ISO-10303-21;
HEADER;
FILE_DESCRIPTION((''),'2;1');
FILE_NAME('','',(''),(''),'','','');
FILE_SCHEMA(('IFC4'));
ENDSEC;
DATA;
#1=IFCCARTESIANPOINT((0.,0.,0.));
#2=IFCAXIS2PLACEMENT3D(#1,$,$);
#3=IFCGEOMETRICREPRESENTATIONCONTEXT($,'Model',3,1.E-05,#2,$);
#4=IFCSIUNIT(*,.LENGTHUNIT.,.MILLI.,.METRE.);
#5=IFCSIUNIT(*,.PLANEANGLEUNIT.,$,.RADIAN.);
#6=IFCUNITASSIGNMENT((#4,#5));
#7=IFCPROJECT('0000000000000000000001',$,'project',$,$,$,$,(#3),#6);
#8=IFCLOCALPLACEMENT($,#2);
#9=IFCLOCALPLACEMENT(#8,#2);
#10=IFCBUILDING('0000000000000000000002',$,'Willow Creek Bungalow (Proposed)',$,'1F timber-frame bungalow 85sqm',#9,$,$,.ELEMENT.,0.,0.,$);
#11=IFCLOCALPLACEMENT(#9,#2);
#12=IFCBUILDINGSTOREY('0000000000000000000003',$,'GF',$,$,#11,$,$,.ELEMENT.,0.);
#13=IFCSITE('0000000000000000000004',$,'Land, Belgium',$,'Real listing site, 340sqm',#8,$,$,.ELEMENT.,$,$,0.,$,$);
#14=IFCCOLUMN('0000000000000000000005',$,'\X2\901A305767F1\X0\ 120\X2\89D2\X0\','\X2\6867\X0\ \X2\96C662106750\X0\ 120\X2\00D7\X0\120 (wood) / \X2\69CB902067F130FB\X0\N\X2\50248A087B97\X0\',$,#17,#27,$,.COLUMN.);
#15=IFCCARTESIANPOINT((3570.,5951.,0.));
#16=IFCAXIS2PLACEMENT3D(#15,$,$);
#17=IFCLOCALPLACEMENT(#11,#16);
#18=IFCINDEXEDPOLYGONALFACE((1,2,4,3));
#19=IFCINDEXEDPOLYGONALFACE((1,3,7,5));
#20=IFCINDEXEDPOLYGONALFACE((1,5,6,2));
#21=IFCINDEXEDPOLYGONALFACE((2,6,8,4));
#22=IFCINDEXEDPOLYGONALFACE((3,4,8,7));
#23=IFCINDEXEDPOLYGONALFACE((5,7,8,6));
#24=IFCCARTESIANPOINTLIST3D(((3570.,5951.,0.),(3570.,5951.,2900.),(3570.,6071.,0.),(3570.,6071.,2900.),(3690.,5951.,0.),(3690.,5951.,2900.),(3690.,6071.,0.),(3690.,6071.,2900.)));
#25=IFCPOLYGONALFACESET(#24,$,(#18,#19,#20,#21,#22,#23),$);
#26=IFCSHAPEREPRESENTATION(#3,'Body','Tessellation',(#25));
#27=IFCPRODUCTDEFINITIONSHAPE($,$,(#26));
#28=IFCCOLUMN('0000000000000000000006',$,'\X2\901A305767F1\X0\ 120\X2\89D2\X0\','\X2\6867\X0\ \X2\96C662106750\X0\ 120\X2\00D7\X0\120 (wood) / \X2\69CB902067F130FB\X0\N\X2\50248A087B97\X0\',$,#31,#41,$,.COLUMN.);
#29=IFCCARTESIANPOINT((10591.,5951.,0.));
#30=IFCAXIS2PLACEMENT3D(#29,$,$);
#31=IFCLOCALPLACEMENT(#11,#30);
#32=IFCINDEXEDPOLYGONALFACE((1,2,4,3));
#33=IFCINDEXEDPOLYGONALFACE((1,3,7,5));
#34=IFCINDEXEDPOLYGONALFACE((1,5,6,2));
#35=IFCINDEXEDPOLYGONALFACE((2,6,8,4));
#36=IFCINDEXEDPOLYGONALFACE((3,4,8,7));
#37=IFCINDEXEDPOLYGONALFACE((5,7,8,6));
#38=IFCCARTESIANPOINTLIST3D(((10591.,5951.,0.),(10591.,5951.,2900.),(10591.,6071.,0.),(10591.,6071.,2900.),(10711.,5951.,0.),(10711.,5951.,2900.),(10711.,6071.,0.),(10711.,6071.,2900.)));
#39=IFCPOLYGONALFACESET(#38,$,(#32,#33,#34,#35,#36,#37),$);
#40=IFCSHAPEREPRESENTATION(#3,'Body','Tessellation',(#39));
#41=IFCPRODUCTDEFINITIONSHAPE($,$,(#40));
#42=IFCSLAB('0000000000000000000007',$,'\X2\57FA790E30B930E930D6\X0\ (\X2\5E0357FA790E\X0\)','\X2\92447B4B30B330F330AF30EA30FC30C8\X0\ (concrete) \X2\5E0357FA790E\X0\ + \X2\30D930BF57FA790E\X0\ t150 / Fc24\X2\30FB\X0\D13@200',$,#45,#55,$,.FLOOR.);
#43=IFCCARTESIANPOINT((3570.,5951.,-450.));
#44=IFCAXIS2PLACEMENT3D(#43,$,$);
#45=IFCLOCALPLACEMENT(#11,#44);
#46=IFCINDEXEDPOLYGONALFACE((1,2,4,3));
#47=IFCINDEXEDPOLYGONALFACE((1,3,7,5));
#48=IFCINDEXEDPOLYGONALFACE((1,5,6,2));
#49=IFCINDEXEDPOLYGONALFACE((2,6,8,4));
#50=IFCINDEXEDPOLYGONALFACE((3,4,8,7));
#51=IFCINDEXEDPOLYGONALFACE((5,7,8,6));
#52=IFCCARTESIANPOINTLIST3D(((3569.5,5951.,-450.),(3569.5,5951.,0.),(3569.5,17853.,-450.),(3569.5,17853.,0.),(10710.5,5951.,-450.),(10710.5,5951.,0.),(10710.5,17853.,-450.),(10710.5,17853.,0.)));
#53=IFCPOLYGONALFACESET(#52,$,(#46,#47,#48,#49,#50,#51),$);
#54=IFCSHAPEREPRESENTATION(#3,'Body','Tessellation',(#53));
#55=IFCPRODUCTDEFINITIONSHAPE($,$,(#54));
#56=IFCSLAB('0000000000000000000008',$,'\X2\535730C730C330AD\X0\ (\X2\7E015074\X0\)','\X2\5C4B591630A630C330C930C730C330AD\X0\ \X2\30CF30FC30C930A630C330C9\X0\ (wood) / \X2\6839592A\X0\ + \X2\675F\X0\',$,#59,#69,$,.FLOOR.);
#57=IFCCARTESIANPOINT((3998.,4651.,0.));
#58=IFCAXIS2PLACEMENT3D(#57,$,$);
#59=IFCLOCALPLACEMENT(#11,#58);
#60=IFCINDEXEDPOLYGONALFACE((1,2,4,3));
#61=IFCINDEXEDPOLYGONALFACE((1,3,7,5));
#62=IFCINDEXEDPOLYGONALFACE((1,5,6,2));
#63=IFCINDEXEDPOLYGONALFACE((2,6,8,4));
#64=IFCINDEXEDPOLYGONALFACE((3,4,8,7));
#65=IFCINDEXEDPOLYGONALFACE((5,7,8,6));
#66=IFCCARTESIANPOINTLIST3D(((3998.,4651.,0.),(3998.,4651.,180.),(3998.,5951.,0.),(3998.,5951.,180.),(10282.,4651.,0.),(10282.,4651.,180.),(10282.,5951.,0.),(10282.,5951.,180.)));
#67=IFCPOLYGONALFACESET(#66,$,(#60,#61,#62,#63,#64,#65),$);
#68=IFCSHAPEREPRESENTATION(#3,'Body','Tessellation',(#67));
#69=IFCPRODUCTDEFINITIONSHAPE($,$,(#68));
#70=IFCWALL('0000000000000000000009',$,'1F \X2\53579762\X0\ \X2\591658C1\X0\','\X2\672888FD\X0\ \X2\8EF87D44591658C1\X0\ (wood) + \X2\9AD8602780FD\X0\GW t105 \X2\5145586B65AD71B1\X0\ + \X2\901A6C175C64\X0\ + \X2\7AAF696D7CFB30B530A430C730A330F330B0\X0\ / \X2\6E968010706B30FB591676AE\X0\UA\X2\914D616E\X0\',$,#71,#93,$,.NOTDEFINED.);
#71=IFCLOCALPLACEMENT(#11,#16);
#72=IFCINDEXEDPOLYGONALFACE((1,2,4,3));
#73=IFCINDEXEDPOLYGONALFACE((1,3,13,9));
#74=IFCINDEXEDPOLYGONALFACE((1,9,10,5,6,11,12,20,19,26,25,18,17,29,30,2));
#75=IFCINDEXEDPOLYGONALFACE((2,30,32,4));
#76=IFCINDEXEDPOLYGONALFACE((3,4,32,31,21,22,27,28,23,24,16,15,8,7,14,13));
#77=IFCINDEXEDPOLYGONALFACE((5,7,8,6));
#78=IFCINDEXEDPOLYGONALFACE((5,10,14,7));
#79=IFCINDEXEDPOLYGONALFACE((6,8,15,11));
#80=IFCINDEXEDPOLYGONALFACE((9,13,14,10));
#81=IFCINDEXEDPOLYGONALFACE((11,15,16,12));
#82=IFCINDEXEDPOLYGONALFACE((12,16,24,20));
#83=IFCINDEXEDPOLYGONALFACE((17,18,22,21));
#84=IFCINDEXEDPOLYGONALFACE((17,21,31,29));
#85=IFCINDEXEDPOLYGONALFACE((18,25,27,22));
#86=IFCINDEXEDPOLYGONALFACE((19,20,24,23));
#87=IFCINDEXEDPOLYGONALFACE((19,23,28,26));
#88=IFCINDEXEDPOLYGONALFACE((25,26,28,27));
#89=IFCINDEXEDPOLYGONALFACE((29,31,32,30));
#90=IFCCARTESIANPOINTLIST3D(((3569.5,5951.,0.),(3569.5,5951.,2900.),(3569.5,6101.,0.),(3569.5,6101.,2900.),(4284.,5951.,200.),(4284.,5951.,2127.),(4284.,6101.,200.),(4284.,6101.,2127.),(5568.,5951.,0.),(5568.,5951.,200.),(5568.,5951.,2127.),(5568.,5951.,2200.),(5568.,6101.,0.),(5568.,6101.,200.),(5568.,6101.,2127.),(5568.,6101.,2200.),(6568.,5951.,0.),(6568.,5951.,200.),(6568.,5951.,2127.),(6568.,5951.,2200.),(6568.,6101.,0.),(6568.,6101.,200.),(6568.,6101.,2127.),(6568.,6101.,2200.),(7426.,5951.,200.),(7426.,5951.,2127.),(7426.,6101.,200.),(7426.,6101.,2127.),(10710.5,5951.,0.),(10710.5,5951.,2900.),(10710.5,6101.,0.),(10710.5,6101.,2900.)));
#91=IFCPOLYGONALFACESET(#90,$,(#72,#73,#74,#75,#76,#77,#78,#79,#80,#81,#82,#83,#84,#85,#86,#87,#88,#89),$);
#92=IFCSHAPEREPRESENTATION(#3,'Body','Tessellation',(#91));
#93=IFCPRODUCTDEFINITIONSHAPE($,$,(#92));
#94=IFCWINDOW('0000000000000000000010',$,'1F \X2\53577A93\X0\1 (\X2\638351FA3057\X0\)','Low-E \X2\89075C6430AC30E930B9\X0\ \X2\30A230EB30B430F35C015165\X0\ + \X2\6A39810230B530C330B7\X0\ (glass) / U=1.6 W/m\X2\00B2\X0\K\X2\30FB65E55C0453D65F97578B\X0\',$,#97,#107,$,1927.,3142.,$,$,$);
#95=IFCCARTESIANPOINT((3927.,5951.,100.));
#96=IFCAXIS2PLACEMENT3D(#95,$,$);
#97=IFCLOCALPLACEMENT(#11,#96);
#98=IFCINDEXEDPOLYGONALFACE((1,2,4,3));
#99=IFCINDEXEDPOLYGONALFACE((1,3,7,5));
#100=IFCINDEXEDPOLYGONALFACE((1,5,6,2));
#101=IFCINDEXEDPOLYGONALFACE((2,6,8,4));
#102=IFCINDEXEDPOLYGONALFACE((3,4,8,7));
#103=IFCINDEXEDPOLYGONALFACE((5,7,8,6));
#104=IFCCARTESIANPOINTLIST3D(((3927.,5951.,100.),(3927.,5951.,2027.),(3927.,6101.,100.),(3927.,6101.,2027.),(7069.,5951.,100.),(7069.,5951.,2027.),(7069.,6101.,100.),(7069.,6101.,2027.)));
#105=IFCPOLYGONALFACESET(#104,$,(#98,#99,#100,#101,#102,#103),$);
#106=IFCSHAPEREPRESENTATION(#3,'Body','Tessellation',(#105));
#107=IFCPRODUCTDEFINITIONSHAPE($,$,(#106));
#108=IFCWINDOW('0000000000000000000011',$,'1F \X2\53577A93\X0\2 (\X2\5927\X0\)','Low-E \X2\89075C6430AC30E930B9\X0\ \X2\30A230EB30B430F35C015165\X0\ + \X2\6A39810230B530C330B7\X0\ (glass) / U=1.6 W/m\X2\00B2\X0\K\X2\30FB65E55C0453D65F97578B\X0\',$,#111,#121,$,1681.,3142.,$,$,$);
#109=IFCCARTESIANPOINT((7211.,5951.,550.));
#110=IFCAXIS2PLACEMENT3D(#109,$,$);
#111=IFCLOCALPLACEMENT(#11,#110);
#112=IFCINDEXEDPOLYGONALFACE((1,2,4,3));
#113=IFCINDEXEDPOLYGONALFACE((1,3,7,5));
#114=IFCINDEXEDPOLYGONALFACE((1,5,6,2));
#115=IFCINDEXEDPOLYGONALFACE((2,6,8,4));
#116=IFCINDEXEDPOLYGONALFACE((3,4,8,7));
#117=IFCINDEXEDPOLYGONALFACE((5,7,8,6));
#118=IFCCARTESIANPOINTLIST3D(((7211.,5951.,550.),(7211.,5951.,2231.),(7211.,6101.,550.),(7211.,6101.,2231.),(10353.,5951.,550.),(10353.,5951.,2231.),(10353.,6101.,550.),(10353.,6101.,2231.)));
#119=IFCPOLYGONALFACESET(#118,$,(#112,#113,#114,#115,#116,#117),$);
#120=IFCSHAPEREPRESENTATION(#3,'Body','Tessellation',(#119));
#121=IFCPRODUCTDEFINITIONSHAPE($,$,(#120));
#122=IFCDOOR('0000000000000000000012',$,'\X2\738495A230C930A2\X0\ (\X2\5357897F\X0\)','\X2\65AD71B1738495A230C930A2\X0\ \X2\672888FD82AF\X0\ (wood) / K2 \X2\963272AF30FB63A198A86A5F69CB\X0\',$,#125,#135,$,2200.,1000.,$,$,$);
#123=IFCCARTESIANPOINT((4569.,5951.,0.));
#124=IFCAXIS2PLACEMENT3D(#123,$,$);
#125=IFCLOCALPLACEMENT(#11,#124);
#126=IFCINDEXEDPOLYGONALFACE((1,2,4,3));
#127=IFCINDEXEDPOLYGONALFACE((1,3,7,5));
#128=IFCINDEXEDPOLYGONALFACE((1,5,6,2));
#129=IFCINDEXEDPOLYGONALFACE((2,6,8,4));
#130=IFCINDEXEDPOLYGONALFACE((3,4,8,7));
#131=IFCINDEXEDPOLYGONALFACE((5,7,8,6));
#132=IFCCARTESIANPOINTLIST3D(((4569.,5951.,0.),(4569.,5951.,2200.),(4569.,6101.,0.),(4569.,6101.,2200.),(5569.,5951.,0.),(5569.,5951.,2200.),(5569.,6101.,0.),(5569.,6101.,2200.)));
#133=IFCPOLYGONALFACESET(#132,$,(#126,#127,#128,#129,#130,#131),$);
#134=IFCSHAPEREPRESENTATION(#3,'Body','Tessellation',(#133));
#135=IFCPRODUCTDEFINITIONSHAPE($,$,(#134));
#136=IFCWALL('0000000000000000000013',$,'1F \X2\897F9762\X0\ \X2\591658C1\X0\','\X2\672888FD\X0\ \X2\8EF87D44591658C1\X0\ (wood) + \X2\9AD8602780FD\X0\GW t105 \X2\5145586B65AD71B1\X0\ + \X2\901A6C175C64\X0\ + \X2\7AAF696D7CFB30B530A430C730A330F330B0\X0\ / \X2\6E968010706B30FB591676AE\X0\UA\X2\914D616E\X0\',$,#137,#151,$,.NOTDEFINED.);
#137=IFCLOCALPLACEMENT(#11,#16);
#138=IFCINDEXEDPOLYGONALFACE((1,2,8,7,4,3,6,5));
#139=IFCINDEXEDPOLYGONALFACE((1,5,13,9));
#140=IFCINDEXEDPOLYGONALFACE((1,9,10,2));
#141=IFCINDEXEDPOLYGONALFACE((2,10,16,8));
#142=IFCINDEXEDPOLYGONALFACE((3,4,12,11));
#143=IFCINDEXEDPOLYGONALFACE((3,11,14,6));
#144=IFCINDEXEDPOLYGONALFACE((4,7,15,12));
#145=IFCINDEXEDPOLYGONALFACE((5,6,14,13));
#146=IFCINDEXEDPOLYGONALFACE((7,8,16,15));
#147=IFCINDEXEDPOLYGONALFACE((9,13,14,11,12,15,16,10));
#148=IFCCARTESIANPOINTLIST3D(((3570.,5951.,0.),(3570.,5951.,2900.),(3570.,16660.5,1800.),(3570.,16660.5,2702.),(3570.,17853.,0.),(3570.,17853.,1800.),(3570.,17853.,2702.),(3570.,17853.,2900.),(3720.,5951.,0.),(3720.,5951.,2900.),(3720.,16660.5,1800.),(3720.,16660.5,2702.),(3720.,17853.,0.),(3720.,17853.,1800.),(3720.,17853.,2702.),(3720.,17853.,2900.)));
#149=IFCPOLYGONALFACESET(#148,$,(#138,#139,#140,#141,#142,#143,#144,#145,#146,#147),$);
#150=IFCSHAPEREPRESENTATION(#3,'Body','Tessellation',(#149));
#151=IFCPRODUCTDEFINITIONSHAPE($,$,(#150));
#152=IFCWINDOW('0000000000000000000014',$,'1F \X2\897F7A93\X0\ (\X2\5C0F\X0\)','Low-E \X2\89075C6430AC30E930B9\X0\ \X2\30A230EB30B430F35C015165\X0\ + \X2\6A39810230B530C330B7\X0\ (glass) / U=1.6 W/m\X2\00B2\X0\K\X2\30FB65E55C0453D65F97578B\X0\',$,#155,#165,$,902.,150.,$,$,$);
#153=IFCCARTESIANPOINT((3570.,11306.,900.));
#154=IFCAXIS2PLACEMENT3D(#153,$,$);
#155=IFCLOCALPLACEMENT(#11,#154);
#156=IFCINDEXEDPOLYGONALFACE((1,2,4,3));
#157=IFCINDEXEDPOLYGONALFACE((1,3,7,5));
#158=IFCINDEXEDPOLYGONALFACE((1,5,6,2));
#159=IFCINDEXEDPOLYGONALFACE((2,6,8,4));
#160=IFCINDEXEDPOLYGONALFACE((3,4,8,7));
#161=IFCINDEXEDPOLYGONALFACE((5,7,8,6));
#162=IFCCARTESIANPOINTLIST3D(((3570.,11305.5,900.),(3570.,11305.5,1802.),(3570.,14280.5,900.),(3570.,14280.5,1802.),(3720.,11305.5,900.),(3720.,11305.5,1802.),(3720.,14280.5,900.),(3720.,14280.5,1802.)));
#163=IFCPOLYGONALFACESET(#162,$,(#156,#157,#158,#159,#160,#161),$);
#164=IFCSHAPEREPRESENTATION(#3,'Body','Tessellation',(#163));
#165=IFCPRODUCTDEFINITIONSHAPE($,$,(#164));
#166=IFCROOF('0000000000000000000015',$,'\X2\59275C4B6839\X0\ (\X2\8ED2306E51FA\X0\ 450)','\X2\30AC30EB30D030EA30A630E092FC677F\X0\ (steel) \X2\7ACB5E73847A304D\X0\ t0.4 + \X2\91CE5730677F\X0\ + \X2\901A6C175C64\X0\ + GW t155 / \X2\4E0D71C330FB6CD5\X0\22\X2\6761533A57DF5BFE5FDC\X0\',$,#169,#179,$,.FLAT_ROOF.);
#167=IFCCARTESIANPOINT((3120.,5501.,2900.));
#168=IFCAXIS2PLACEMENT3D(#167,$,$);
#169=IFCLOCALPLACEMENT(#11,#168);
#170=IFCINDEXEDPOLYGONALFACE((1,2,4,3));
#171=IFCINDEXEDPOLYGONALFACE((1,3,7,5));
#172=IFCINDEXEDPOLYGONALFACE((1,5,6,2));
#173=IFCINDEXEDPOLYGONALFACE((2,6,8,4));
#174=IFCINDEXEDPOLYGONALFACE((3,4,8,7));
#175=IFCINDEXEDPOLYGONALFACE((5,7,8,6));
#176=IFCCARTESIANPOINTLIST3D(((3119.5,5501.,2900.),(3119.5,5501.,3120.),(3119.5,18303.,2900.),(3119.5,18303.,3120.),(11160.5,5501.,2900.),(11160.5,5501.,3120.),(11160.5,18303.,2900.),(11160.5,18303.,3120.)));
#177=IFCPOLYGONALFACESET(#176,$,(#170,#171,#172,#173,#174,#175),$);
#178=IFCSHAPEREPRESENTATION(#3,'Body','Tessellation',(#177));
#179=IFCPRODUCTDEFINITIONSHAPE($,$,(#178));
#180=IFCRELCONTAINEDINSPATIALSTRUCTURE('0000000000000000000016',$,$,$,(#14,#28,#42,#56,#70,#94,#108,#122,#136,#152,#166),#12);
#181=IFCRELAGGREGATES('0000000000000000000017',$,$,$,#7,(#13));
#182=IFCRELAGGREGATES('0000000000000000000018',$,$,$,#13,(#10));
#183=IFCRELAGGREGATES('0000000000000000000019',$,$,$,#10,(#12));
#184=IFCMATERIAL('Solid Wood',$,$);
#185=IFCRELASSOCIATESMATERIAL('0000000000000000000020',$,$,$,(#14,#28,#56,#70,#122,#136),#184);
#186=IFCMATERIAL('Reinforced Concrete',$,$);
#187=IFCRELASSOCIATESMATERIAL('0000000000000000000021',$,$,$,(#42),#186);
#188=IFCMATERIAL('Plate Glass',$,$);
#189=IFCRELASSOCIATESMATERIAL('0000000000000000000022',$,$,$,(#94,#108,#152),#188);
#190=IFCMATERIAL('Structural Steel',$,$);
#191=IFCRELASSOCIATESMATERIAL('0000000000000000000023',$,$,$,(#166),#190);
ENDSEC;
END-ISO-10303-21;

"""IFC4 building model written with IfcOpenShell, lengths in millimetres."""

from ifc_helpers import new_model, si_unit, frame, frame_2d, origin, place, context, project, spatial, rectangle, extrude, material, element, fill, save


model = new_model("IFC4")

# Units and contexts
model_context = context("Model", 3, precision=1e-05, world=origin())
ifc_project = project(units=[si_unit("LENGTHUNIT", "METRE", prefix="MILLI"), si_unit("PLANEANGLEUNIT", "RADIAN")], contexts=[model_context])

# Site, building, storey
site_placement = place(None, origin())
site = spatial("IfcSite", under=ifc_project, at=site_placement, Name="Land, Belgium", ObjectType="Real listing site, 340sqm", CompositionType="ELEMENT", RefElevation=0.0)
building_placement = place(site_placement, origin())
building = spatial("IfcBuilding", under=site, at=building_placement, Name="Willow Creek Bungalow (Proposed)", ObjectType="1F timber-frame bungalow 85sqm", CompositionType="ELEMENT", ElevationOfRefHeight=0.0, ElevationOfTerrain=0.0)
storey_placement = place(building_placement, origin())
storey = spatial("IfcBuildingStorey", under=building, at=storey_placement, Name="GF", CompositionType="ELEMENT", Elevation=0.0)

# Columns
ifc_material_1 = material(Name="Solid Wood")
column_1_placement = place(storey_placement, frame((3570.0, 5951.0, 0.0)))
element("IfcColumn", 1, at=column_1_placement, inside=storey, material=ifc_material_1, Name="通し柱 120角", Description="桧 集成材 120×120 (wood) / 構造柱・N値計算", PredefinedType="COLUMN", context=model_context, shape_type="SweptSolid", body=[
    extrude(rectangle(XDim=120.0, YDim=120.0, at=frame_2d((60.0, 60.0))), frame((3570.0, 5951.0, 0.0)), (0.0, 0.0, 1.0), 2900.0),
])
column_2_placement = place(storey_placement, frame((10591.0, 5951.0, 0.0)))
element("IfcColumn", 2, at=column_2_placement, inside=storey, material=ifc_material_1, Name="通し柱 120角", Description="桧 集成材 120×120 (wood) / 構造柱・N値計算", PredefinedType="COLUMN", context=model_context, shape_type="SweptSolid", body=[
    extrude(rectangle(XDim=120.0, YDim=120.0, at=frame_2d((60.0, 60.0))), frame((10591.0, 5951.0, 0.0)), (0.0, 0.0, 1.0), 2900.0),
])

# Slabs
ifc_material_2 = material(Name="Reinforced Concrete")
slab_1_placement = place(storey_placement, frame((3570.0, 5951.0, -450.0)))
element("IfcSlab", 3, at=slab_1_placement, inside=storey, material=ifc_material_2, Name="基礎スラブ (布基礎)", Description="鉄筋コンクリート (concrete) 布基礎 + ベタ基礎 t150 / Fc24・D13@200", PredefinedType="FLOOR", context=model_context, shape_type="SweptSolid", body=[
    extrude(rectangle(XDim=7141.0, YDim=11902.0, at=frame_2d((3570.0, 5951.0))), frame((3570.0, 5951.0, -450.0)), (0.0, 0.0, 1.0), 450.0),
])
slab_2_placement = place(storey_placement, frame((3998.0, 4651.0, 0.0)))
element("IfcSlab", 4, at=slab_2_placement, inside=storey, material=ifc_material_1, Name="南デッキ (縁側)", Description="屋外ウッドデッキ ハードウッド (wood) / 根太 + 束", PredefinedType="FLOOR", context=model_context, shape_type="SweptSolid", body=[
    extrude(rectangle(XDim=6284.0, YDim=1300.0, at=frame_2d((3142.0, 650.0))), frame((3998.0, 4651.0, 0.0)), (0.0, 0.0, 1.0), 180.0),
])

# Wall, openings, windows, door
wall_1_placement = place(storey_placement, frame((3570.0, 5951.0, 0.0)))
wall_1 = element("IfcWall", 5, at=wall_1_placement, inside=storey, material=ifc_material_1, Name="1F 南面 外壁", Description="木製 軸組外壁 (wood) + 高性能GW t105 充填断熱 + 通気層 + 窯業系サイディング / 準耐火・外皮UA配慮", PredefinedType="NOTDEFINED", context=model_context, shape_type="SweptSolid", body=[
    extrude(rectangle(XDim=7141.0, YDim=150.0, at=frame_2d((3570.0, 75.0))), frame((3570.0, 5951.0, 0.0)), (0.0, 0.0, 1.0), 2900.0),
])
opening_1_placement = place(storey_placement, frame((3927.0, 5951.0, 100.0)))
opening_1 = element("IfcOpeningElement", 6, at=opening_1_placement, cuts=wall_1, PredefinedType="NOTDEFINED", context=model_context, shape_type="SweptSolid", body=[
    extrude(rectangle(XDim=3142.0, YDim=150.0, at=frame_2d((1571.0, 75.0))), frame((3927.0, 5951.0, 100.0)), (0.0, 0.0, 1.0), 1927.0),
])
opening_2_placement = place(storey_placement, frame((7211.0, 5951.0, 550.0)))
opening_2 = element("IfcOpeningElement", 7, at=opening_2_placement, cuts=wall_1, PredefinedType="NOTDEFINED", context=model_context, shape_type="SweptSolid", body=[
    extrude(rectangle(XDim=3142.0, YDim=150.0, at=frame_2d((1571.0, 75.0))), frame((7211.0, 5951.0, 550.0)), (0.0, 0.0, 1.0), 1681.0),
])
opening_3_placement = place(storey_placement, frame((4569.0, 5951.0, 0.0)))
opening_3 = element("IfcOpeningElement", 8, at=opening_3_placement, cuts=wall_1, PredefinedType="NOTDEFINED", context=model_context, shape_type="SweptSolid", body=[
    extrude(rectangle(XDim=1000.0, YDim=150.0, at=frame_2d((500.0, 75.0))), frame((4569.0, 5951.0, 0.0)), (0.0, 0.0, 1.0), 2200.0),
])
ifc_material_3 = material(Name="Plate Glass")
window_1_placement = place(storey_placement, frame((3927.0, 5951.0, 100.0)))
window_1 = element("IfcWindow", 9, at=window_1_placement, inside=storey, material=ifc_material_3, Name="1F 南窓1 (掃出し)", Description="Low-E 複層ガラス アルゴン封入 + 樹脂サッシ (glass) / U=1.6 W/m²K・日射取得型", OverallHeight=1927.0, OverallWidth=3142.0, context=model_context, shape_type="SweptSolid", body=[
    extrude(rectangle(XDim=3142.0, YDim=150.0, at=frame_2d((1571.0, 75.0))), frame((3927.0, 5951.0, 100.0)), (0.0, 0.0, 1.0), 1927.0),
])
fill(opening_1, window_1)
window_2_placement = place(storey_placement, frame((7211.0, 5951.0, 550.0)))
window_2 = element("IfcWindow", 10, at=window_2_placement, inside=storey, material=ifc_material_3, Name="1F 南窓2 (大)", Description="Low-E 複層ガラス アルゴン封入 + 樹脂サッシ (glass) / U=1.6 W/m²K・日射取得型", OverallHeight=1681.0, OverallWidth=3142.0, context=model_context, shape_type="SweptSolid", body=[
    extrude(rectangle(XDim=3142.0, YDim=150.0, at=frame_2d((1571.0, 75.0))), frame((7211.0, 5951.0, 550.0)), (0.0, 0.0, 1.0), 1681.0),
])
fill(opening_2, window_2)
door_placement = place(storey_placement, frame((4569.0, 5951.0, 0.0)))
door = element("IfcDoor", 11, at=door_placement, inside=storey, material=ifc_material_1, Name="玄関ドア (南西)", Description="断熱玄関ドア 木製芯 (wood) / K2 防犯・採風機構", OverallHeight=2200.0, OverallWidth=1000.0, context=model_context, shape_type="SweptSolid", body=[
    extrude(rectangle(XDim=1000.0, YDim=150.0, at=frame_2d((500.0, 75.0))), frame((4569.0, 5951.0, 0.0)), (0.0, 0.0, 1.0), 2200.0),
])
fill(opening_3, door)

# Wall, opening, window
wall_2_placement = place(storey_placement, frame((3570.0, 5951.0, 0.0)))
wall_2 = element("IfcWall", 12, at=wall_2_placement, inside=storey, material=ifc_material_1, Name="1F 西面 外壁", Description="木製 軸組外壁 (wood) + 高性能GW t105 充填断熱 + 通気層 + 窯業系サイディング / 準耐火・外皮UA配慮", PredefinedType="NOTDEFINED", context=model_context, shape_type="SweptSolid", body=[
    extrude(rectangle(XDim=150.0, YDim=11902.0, at=frame_2d((75.0, 5951.0))), frame((3570.0, 5951.0, 0.0)), (0.0, 0.0, 1.0), 2900.0),
])
opening_4_placement = place(storey_placement, frame((3570.0, 11306.0, 900.0)))
opening_4 = element("IfcOpeningElement", 13, at=opening_4_placement, cuts=wall_2, PredefinedType="NOTDEFINED", context=model_context, shape_type="SweptSolid", body=[
    extrude(rectangle(XDim=150.0, YDim=2975.0, at=frame_2d((75.0, 1487.0))), frame((3570.0, 11306.0, 900.0)), (0.0, 0.0, 1.0), 902.0),
])
window_3_placement = place(storey_placement, frame((3570.0, 11306.0, 900.0)))
window_3 = element("IfcWindow", 14, at=window_3_placement, inside=storey, material=ifc_material_3, Name="1F 西窓 (小)", Description="Low-E 複層ガラス アルゴン封入 + 樹脂サッシ (glass) / U=1.6 W/m²K・日射取得型", OverallHeight=902.0, OverallWidth=150.0, context=model_context, shape_type="SweptSolid", body=[
    extrude(rectangle(XDim=150.0, YDim=2975.0, at=frame_2d((75.0, 1487.0))), frame((3570.0, 11306.0, 900.0)), (0.0, 0.0, 1.0), 902.0),
])
fill(opening_4, window_3)

# Roof
ifc_material_4 = material(Name="Structural Steel")
roof_placement = place(storey_placement, frame((3120.0, 5501.0, 2900.0)))
element("IfcRoof", 15, at=roof_placement, inside=storey, material=ifc_material_4, Name="大屋根 (軒の出 450)", Description="ガルバリウム鋼板 (steel) 立平葺き t0.4 + 野地板 + 通気層 + GW t155 / 不燃・法22条区域対応", PredefinedType="FLAT_ROOF", context=model_context, shape_type="SweptSolid", body=[
    extrude(rectangle(XDim=8041.0, YDim=12802.0, at=frame_2d((4020.0, 6401.0))), frame((3120.0, 5501.0, 2900.0)), (0.0, 0.0, 1.0), 220.0),
])

save(model, "model.ifc")
